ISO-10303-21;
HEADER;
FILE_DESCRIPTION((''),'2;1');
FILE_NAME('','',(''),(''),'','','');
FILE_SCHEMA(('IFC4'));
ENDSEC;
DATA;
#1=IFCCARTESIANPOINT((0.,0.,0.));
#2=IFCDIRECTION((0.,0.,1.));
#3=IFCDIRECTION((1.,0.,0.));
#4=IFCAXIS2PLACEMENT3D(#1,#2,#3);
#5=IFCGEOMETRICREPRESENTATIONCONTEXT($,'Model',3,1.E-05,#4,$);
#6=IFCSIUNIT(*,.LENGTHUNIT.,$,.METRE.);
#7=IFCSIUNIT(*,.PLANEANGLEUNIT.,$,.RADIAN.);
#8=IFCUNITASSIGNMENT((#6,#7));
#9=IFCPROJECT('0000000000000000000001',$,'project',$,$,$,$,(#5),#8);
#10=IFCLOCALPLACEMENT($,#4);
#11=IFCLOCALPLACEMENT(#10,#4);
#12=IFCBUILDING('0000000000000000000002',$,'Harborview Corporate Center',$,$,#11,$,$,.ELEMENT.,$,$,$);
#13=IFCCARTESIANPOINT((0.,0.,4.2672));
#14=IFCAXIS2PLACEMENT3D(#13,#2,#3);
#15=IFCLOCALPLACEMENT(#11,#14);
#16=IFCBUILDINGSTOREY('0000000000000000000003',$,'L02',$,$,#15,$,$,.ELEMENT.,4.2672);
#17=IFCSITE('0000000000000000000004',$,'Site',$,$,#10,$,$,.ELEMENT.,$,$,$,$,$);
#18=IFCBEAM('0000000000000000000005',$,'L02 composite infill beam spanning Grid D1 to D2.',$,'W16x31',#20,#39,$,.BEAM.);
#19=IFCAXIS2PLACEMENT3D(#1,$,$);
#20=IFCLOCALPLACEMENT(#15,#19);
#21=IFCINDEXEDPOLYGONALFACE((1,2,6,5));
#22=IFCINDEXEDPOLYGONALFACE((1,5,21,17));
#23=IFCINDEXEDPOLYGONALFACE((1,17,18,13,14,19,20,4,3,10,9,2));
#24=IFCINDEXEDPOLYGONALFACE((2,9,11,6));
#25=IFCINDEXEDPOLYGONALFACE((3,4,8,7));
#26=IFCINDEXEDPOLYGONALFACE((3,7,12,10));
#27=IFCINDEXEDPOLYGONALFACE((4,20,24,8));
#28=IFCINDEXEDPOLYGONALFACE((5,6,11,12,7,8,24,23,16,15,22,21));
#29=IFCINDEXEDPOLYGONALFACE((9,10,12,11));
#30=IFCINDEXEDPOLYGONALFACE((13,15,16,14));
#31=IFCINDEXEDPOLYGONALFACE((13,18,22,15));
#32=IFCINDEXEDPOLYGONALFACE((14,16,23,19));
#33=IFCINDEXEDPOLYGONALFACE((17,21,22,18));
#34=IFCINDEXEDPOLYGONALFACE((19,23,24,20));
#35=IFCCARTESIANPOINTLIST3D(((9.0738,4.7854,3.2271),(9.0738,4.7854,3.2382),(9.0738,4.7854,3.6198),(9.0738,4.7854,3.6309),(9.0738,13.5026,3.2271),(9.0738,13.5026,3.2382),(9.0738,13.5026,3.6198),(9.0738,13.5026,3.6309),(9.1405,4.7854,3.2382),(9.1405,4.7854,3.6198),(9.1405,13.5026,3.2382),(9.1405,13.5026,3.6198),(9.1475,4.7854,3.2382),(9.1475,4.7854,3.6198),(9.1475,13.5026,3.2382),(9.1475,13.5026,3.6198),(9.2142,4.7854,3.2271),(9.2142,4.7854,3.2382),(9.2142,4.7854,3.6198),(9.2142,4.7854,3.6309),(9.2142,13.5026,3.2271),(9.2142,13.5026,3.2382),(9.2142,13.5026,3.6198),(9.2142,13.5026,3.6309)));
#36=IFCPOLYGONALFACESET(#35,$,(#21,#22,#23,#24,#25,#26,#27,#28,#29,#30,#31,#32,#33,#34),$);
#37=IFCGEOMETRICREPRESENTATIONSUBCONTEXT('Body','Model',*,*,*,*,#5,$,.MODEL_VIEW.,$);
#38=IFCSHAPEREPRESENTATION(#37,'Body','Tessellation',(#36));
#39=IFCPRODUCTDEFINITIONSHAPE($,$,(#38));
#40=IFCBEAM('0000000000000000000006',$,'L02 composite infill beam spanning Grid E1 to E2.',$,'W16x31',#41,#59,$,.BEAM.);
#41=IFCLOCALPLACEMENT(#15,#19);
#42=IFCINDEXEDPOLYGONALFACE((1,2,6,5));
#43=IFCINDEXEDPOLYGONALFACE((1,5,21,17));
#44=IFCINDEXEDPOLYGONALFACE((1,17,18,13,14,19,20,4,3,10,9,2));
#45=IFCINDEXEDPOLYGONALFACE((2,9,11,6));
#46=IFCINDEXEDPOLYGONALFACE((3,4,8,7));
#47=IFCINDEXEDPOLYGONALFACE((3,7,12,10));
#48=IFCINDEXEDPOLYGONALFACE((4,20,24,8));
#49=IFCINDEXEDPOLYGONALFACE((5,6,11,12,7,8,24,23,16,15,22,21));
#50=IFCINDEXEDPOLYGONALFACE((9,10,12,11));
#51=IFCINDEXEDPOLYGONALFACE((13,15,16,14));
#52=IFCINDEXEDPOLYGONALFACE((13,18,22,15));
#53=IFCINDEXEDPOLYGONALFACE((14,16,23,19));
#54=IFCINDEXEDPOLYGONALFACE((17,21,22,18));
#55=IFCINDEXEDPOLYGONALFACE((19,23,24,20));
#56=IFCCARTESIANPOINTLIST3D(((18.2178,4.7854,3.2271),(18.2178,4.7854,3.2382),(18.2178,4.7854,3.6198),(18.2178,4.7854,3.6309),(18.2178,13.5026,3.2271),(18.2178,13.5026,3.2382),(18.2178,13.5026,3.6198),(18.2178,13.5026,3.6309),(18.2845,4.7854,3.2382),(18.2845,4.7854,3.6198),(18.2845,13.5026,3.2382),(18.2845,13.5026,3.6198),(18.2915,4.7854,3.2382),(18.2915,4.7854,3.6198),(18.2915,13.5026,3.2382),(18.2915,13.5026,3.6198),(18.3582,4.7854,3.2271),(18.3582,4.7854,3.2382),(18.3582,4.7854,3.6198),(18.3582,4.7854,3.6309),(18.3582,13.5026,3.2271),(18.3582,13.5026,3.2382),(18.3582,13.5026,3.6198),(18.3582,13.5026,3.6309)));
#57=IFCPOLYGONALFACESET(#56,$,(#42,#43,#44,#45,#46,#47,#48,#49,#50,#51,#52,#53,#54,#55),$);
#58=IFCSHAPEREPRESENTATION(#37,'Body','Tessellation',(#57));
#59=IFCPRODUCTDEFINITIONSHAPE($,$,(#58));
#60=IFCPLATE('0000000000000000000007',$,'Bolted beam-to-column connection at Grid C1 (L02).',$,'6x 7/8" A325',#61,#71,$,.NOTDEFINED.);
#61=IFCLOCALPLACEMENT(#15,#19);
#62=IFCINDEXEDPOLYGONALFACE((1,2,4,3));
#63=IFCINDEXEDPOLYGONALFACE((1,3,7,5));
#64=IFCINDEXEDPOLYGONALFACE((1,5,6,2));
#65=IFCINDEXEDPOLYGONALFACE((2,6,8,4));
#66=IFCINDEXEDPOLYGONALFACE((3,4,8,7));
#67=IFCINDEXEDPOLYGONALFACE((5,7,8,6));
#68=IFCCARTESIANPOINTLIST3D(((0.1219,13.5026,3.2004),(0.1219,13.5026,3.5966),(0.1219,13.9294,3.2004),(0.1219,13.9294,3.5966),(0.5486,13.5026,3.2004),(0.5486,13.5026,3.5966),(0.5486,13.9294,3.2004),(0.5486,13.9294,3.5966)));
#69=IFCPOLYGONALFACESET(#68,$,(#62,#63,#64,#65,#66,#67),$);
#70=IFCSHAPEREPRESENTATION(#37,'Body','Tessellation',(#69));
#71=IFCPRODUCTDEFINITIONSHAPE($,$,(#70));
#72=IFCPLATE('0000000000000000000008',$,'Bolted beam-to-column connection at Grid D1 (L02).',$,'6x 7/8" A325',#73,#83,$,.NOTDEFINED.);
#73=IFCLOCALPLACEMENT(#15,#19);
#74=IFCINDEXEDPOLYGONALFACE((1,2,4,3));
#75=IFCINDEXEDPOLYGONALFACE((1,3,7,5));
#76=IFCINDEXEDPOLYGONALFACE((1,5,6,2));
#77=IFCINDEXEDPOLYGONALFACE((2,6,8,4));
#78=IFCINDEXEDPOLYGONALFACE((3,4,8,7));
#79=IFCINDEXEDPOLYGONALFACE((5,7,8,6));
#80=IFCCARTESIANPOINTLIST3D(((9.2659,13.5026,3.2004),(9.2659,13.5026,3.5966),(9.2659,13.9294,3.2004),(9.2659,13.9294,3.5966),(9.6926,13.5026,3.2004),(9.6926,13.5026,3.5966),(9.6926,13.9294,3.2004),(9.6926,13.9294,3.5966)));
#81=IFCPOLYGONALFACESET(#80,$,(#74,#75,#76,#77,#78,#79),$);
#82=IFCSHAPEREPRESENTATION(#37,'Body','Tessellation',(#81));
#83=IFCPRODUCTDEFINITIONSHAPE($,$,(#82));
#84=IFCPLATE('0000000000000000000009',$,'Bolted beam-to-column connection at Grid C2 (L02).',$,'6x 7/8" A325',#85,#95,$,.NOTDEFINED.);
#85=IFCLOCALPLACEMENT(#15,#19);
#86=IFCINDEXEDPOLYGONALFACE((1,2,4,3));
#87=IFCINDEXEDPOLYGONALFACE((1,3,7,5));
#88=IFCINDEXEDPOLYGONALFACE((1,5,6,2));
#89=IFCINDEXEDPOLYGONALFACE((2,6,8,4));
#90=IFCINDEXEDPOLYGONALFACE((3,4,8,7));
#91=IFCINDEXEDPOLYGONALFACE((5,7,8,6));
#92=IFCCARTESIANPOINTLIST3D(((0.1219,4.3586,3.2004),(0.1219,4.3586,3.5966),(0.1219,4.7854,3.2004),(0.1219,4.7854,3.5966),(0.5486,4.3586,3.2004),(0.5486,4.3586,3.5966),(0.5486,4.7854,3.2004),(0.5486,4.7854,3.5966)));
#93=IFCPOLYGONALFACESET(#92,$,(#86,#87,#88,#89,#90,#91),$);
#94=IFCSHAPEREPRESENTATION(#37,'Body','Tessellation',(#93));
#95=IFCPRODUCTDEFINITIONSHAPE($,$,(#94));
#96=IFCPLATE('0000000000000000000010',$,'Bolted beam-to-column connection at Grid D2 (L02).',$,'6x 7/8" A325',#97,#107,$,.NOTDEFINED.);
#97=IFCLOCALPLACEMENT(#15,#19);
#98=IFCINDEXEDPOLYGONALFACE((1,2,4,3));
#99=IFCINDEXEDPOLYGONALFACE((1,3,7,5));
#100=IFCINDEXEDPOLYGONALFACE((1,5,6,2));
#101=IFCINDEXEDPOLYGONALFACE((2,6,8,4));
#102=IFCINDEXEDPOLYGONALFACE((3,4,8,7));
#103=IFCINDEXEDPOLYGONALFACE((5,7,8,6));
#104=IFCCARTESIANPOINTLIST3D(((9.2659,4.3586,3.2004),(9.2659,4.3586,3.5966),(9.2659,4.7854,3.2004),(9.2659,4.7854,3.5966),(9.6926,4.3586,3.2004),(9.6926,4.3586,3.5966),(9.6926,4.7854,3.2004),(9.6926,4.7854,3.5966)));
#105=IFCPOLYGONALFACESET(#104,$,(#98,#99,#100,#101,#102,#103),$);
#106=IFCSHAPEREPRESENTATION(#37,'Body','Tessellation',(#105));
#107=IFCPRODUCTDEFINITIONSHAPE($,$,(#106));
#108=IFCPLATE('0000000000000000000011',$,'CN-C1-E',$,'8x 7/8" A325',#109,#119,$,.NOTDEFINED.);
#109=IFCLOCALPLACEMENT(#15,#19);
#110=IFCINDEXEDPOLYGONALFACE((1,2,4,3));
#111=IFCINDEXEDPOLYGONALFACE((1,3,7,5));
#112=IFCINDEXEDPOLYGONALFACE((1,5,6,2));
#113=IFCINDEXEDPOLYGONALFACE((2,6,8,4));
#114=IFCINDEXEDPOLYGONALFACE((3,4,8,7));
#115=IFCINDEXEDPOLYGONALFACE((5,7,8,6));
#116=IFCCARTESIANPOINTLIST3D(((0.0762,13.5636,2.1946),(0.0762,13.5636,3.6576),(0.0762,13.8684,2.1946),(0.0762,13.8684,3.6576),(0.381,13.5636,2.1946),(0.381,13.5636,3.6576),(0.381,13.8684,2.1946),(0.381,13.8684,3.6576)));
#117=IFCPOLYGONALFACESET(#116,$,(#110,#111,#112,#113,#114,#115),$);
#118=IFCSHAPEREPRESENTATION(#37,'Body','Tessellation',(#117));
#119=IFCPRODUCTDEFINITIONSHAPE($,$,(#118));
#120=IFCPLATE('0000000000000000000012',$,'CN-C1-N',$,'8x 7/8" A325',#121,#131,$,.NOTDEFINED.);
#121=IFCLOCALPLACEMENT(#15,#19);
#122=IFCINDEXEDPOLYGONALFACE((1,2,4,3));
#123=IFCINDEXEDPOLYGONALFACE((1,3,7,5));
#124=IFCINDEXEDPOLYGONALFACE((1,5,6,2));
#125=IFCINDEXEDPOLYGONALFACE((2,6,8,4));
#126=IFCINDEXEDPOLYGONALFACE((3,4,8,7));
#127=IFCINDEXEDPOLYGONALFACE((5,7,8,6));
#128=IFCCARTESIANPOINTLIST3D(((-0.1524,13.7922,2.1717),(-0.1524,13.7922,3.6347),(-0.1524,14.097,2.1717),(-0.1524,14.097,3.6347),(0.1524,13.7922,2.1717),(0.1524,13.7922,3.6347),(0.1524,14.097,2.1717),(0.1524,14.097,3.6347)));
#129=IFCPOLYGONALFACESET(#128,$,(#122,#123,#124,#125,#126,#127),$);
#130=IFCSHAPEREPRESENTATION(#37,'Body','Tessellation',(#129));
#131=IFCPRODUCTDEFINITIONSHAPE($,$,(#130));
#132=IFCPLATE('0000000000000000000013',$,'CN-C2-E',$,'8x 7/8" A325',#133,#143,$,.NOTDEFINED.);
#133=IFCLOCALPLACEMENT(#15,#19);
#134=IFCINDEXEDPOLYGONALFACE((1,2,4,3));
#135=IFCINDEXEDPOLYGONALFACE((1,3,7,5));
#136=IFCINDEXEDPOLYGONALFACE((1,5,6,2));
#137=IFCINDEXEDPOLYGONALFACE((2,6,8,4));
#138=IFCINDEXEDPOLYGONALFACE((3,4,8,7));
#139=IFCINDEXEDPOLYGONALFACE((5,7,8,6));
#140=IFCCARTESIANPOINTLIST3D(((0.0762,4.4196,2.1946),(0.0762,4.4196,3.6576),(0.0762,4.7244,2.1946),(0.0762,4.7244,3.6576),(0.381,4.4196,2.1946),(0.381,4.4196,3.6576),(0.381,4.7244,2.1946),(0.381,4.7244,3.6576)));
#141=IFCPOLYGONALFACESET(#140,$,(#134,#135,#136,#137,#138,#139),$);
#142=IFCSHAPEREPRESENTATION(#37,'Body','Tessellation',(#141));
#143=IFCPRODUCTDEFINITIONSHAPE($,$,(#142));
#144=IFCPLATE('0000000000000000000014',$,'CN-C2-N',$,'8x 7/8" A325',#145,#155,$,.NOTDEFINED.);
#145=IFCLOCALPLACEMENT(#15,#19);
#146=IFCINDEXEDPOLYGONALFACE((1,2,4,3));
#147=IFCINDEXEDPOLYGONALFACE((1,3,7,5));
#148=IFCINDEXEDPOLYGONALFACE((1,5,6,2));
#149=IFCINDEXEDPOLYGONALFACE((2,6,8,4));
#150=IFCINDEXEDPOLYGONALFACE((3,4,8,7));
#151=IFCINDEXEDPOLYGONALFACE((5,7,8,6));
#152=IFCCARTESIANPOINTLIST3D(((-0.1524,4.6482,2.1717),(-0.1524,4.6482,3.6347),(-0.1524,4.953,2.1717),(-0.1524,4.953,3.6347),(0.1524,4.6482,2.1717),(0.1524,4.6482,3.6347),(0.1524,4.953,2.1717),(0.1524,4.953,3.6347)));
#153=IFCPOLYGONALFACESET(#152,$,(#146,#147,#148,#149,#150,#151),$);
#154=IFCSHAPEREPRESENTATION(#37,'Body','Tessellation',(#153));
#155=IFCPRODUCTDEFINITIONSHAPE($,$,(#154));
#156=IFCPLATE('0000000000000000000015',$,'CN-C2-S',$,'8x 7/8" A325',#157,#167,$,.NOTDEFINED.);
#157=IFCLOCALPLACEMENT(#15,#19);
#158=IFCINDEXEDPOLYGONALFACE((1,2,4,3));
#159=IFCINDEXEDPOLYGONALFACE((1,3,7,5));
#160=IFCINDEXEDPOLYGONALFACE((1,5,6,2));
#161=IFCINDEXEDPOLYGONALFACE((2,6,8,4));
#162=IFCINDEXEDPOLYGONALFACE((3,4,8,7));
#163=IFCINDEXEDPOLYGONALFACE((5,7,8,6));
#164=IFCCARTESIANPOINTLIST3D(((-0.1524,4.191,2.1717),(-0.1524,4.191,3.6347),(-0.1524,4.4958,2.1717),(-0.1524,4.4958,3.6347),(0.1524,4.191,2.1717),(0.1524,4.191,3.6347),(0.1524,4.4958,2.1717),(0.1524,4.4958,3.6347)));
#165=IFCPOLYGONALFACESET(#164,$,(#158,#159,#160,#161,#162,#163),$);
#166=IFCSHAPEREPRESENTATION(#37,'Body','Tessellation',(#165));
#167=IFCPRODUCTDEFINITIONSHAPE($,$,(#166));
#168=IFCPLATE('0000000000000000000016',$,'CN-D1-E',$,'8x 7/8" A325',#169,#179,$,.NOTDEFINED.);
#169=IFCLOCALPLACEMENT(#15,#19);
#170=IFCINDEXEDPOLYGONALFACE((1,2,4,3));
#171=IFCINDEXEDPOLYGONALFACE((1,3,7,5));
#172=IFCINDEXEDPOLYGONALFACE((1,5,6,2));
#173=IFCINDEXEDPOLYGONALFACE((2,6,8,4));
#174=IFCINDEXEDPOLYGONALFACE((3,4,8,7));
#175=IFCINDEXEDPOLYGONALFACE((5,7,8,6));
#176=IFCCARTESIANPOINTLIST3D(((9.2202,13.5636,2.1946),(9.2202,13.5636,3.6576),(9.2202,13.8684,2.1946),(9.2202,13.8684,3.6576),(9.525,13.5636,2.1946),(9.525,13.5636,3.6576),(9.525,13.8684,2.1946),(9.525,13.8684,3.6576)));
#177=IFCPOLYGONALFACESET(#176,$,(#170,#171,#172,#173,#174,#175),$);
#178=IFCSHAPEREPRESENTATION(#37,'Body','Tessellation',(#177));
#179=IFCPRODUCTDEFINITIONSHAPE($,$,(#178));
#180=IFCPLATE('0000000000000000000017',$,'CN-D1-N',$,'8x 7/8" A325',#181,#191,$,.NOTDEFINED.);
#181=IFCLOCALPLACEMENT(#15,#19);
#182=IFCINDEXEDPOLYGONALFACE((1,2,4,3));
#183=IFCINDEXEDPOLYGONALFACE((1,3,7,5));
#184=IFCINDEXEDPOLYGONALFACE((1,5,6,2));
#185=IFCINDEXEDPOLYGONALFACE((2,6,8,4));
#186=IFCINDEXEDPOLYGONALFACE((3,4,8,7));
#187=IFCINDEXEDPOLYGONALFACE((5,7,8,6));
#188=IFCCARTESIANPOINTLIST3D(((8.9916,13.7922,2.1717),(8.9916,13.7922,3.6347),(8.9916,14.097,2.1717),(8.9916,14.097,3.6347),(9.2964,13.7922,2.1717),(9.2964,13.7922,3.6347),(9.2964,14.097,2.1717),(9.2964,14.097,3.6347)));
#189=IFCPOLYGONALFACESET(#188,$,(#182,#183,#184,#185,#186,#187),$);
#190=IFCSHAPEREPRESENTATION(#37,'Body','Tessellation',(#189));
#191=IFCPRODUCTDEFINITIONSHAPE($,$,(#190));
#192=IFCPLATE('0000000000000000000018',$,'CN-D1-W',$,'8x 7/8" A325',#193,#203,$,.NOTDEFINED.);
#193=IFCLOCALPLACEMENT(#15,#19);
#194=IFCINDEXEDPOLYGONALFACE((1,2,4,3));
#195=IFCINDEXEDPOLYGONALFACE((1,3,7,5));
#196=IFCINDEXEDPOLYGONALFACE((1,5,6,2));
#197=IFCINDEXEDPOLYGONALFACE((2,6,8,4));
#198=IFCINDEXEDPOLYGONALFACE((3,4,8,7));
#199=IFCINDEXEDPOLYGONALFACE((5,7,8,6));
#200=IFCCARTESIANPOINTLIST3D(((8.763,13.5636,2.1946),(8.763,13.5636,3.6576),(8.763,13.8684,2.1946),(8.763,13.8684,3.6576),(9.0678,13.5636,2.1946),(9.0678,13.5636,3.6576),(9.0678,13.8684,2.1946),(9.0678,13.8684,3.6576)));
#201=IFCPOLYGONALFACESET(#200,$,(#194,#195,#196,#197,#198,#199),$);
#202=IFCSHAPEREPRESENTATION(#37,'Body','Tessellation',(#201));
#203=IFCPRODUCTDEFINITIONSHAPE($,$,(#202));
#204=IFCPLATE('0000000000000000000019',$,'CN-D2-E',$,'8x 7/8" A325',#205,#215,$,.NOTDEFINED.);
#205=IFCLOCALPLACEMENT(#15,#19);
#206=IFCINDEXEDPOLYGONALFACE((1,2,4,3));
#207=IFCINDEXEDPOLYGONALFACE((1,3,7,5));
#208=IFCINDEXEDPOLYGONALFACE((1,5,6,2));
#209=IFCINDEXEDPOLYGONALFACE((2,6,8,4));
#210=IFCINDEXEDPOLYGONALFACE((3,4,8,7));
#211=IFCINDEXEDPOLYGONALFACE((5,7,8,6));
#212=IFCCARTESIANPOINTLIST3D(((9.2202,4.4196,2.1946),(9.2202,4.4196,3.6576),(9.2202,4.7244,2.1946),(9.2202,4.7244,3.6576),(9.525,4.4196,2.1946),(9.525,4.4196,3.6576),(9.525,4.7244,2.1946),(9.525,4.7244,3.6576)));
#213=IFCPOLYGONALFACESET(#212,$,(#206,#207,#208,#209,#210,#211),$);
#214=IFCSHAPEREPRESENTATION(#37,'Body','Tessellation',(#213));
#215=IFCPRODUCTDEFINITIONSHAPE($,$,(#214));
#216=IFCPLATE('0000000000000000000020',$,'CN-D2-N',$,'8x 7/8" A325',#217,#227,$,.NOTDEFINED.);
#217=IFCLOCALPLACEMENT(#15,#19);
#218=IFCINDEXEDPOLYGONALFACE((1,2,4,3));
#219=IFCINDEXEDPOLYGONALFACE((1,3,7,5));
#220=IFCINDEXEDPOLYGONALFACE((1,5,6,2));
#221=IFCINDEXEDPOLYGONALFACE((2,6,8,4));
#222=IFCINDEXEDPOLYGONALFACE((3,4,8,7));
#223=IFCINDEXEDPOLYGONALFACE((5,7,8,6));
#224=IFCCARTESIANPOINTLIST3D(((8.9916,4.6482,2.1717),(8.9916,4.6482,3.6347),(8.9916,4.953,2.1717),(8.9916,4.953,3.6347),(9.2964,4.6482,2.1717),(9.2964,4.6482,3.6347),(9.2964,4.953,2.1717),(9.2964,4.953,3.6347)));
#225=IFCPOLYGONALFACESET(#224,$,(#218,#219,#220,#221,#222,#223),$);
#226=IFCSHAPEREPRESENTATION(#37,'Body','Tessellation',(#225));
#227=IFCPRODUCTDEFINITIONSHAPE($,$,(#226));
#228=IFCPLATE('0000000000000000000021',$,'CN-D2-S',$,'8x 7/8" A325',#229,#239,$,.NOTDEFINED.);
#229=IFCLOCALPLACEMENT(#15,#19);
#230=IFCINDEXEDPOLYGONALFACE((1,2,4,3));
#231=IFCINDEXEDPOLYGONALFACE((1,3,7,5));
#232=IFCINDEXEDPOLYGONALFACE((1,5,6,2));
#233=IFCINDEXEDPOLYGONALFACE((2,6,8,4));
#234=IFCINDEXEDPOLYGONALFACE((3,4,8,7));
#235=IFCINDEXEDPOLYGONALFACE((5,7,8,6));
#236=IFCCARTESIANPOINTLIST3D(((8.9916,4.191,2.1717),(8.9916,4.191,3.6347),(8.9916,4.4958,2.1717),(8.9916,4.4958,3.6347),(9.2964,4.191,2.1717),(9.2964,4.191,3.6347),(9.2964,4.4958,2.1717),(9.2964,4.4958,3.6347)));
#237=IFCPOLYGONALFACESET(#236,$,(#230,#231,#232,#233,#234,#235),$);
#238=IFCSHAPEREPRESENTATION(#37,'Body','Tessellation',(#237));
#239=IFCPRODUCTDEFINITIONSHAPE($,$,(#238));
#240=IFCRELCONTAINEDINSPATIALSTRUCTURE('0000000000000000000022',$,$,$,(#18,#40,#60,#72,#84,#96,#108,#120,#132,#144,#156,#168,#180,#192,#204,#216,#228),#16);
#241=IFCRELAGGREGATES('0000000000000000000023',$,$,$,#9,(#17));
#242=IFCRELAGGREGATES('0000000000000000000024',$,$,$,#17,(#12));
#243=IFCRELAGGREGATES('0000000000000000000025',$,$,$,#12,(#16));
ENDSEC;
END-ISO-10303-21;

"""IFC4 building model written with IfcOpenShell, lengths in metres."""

from ifc_helpers import new_model, si_unit, frame, origin_with_axes, place, context, subcontext, project, spatial, rectangle, i_section, extrude, element, save


model = new_model("IFC4")

# Units and contexts
model_context = context("Model", 3, precision=1e-05, world=origin_with_axes())
body_context = subcontext(model_context, "Body", "Model", "MODEL_VIEW")
ifc_project = project(units=[si_unit("LENGTHUNIT", "METRE"), si_unit("PLANEANGLEUNIT", "RADIAN")], contexts=[model_context])

# Site, building, storey
site_placement = place(None, origin_with_axes())
site = spatial("IfcSite", under=ifc_project, at=site_placement, Name="Site", CompositionType="ELEMENT")
building_placement = place(site_placement, origin_with_axes())
building = spatial("IfcBuilding", under=site, at=building_placement, Name="Harborview Corporate Center", CompositionType="ELEMENT")
storey_placement = place(building_placement, frame((0.0, 0.0, 4.2672), z_axis=(0.0, 0.0, 1.0), x_axis=(1.0, 0.0, 0.0)))
storey = spatial("IfcBuildingStorey", under=building, at=storey_placement, Name="L02", CompositionType="ELEMENT", Elevation=4.2672)

# Beams
for number, where, z_axis, x_axis, name in (
    (1, (9.144, 4.7854, 3.429), (0.0, 1.0, 0.0), (-1.0, 0.0, 0.0), "L02 composite infill beam spanning Grid D1 to D2."),
    (2, (18.288, 4.7854, 3.429), (0.0, 1.0, 0.0), (-1.0, 0.0, 0.0), "L02 composite infill beam spanning Grid E1 to E2."),
):
    element("IfcBeam", number, at=place(storey_placement, frame(where, z_axis=z_axis, x_axis=x_axis)), inside=storey, Name=name, ObjectType="W16x31", PredefinedType="BEAM", context=body_context, shape_type="SweptSolid", body=[
        extrude(i_section(OverallWidth=0.1405, OverallDepth=0.4039, WebThickness=0.007, FlangeThickness=0.0112), origin_with_axes(), (0.0, 0.0, 1.0), 8.7173),
    ])

# Plates
plate_1_placement = place(storey_placement, frame((0.3353, 13.716, 3.2004), z_axis=(0.0, 0.0, 1.0), x_axis=(1.0, 0.0, 0.0)))
element("IfcPlate", 3, at=plate_1_placement, inside=storey, Name="Bolted beam-to-column connection at Grid C1 (L02).", ObjectType="6x 7/8\" A325", PredefinedType="NOTDEFINED", context=body_context, shape_type="SweptSolid", body=[
    extrude(rectangle(XDim=0.4267, YDim=0.4267), origin_with_axes(), (0.0, 0.0, 1.0), 0.3962),
])
plate_2_placement = place(storey_placement, frame((9.4793, 13.716, 3.2004), z_axis=(0.0, 0.0, 1.0), x_axis=(1.0, 0.0, 0.0)))
element("IfcPlate", 4, at=plate_2_placement, inside=storey, Name="Bolted beam-to-column connection at Grid D1 (L02).", ObjectType="6x 7/8\" A325", PredefinedType="NOTDEFINED", context=body_context, shape_type="SweptSolid", body=[
    extrude(rectangle(XDim=0.4267, YDim=0.4267), origin_with_axes(), (0.0, 0.0, 1.0), 0.3962),
])
plate_3_placement = place(storey_placement, frame((0.3353, 4.572, 3.2004), z_axis=(0.0, 0.0, 1.0), x_axis=(1.0, 0.0, 0.0)))
element("IfcPlate", 5, at=plate_3_placement, inside=storey, Name="Bolted beam-to-column connection at Grid C2 (L02).", ObjectType="6x 7/8\" A325", PredefinedType="NOTDEFINED", context=body_context, shape_type="SweptSolid", body=[
    extrude(rectangle(XDim=0.4267, YDim=0.4267), origin_with_axes(), (0.0, 0.0, 1.0), 0.3962),
])
plate_4_placement = place(storey_placement, frame((9.4793, 4.572, 3.2004), z_axis=(0.0, 0.0, 1.0), x_axis=(1.0, 0.0, 0.0)))
element("IfcPlate", 6, at=plate_4_placement, inside=storey, Name="Bolted beam-to-column connection at Grid D2 (L02).", ObjectType="6x 7/8\" A325", PredefinedType="NOTDEFINED", context=body_context, shape_type="SweptSolid", body=[
    extrude(rectangle(XDim=0.4267, YDim=0.4267), origin_with_axes(), (0.0, 0.0, 1.0), 0.3962),
])
for number, where, z_axis, x_axis, name in (
    (7, (0.2286, 13.716, 2.1946), (0.0, 0.0, 1.0), (1.0, 0.0, 0.0), "CN-C1-E"),
    (8, (0.0, 13.9446, 2.1717), (0.0, 0.0, 1.0), (1.0, 0.0, 0.0), "CN-C1-N"),
    (9, (0.2286, 4.572, 2.1946), (0.0, 0.0, 1.0), (1.0, 0.0, 0.0), "CN-C2-E"),
    (10, (0.0, 4.8006, 2.1717), (0.0, 0.0, 1.0), (1.0, 0.0, 0.0), "CN-C2-N"),
    (11, (0.0, 4.3434, 2.1717), (0.0, 0.0, 1.0), (1.0, 0.0, 0.0), "CN-C2-S"),
):
    element("IfcPlate", number, at=place(storey_placement, frame(where, z_axis=z_axis, x_axis=x_axis)), inside=storey, Name=name, ObjectType="8x 7/8\" A325", PredefinedType="NOTDEFINED", context=body_context, shape_type="SweptSolid", body=[
        extrude(rectangle(XDim=0.3048, YDim=0.3048), origin_with_axes(), (0.0, 0.0, 1.0), 1.463),
    ])
for number, where, z_axis, x_axis, name in (
    (12, (9.3726, 13.716, 2.1946), (0.0, 0.0, 1.0), (1.0, 0.0, 0.0), "CN-D1-E"),
    (13, (9.144, 13.9446, 2.1717), (0.0, 0.0, 1.0), (1.0, 0.0, 0.0), "CN-D1-N"),
    (14, (8.9154, 13.716, 2.1946), (0.0, 0.0, 1.0), (1.0, 0.0, 0.0), "CN-D1-W"),
    (15, (9.3726, 4.572, 2.1946), (0.0, 0.0, 1.0), (1.0, 0.0, 0.0), "CN-D2-E"),
    (16, (9.144, 4.8006, 2.1717), (0.0, 0.0, 1.0), (1.0, 0.0, 0.0), "CN-D2-N"),
    (17, (9.144, 4.3434, 2.1717), (0.0, 0.0, 1.0), (1.0, 0.0, 0.0), "CN-D2-S"),
):
    element("IfcPlate", number, at=place(storey_placement, frame(where, z_axis=z_axis, x_axis=x_axis)), inside=storey, Name=name, ObjectType="8x 7/8\" A325", PredefinedType="NOTDEFINED", context=body_context, shape_type="SweptSolid", body=[
        extrude(rectangle(XDim=0.3048, YDim=0.3048), origin_with_axes(), (0.0, 0.0, 1.0), 1.463),
    ])

save(model, "model.ifc")
